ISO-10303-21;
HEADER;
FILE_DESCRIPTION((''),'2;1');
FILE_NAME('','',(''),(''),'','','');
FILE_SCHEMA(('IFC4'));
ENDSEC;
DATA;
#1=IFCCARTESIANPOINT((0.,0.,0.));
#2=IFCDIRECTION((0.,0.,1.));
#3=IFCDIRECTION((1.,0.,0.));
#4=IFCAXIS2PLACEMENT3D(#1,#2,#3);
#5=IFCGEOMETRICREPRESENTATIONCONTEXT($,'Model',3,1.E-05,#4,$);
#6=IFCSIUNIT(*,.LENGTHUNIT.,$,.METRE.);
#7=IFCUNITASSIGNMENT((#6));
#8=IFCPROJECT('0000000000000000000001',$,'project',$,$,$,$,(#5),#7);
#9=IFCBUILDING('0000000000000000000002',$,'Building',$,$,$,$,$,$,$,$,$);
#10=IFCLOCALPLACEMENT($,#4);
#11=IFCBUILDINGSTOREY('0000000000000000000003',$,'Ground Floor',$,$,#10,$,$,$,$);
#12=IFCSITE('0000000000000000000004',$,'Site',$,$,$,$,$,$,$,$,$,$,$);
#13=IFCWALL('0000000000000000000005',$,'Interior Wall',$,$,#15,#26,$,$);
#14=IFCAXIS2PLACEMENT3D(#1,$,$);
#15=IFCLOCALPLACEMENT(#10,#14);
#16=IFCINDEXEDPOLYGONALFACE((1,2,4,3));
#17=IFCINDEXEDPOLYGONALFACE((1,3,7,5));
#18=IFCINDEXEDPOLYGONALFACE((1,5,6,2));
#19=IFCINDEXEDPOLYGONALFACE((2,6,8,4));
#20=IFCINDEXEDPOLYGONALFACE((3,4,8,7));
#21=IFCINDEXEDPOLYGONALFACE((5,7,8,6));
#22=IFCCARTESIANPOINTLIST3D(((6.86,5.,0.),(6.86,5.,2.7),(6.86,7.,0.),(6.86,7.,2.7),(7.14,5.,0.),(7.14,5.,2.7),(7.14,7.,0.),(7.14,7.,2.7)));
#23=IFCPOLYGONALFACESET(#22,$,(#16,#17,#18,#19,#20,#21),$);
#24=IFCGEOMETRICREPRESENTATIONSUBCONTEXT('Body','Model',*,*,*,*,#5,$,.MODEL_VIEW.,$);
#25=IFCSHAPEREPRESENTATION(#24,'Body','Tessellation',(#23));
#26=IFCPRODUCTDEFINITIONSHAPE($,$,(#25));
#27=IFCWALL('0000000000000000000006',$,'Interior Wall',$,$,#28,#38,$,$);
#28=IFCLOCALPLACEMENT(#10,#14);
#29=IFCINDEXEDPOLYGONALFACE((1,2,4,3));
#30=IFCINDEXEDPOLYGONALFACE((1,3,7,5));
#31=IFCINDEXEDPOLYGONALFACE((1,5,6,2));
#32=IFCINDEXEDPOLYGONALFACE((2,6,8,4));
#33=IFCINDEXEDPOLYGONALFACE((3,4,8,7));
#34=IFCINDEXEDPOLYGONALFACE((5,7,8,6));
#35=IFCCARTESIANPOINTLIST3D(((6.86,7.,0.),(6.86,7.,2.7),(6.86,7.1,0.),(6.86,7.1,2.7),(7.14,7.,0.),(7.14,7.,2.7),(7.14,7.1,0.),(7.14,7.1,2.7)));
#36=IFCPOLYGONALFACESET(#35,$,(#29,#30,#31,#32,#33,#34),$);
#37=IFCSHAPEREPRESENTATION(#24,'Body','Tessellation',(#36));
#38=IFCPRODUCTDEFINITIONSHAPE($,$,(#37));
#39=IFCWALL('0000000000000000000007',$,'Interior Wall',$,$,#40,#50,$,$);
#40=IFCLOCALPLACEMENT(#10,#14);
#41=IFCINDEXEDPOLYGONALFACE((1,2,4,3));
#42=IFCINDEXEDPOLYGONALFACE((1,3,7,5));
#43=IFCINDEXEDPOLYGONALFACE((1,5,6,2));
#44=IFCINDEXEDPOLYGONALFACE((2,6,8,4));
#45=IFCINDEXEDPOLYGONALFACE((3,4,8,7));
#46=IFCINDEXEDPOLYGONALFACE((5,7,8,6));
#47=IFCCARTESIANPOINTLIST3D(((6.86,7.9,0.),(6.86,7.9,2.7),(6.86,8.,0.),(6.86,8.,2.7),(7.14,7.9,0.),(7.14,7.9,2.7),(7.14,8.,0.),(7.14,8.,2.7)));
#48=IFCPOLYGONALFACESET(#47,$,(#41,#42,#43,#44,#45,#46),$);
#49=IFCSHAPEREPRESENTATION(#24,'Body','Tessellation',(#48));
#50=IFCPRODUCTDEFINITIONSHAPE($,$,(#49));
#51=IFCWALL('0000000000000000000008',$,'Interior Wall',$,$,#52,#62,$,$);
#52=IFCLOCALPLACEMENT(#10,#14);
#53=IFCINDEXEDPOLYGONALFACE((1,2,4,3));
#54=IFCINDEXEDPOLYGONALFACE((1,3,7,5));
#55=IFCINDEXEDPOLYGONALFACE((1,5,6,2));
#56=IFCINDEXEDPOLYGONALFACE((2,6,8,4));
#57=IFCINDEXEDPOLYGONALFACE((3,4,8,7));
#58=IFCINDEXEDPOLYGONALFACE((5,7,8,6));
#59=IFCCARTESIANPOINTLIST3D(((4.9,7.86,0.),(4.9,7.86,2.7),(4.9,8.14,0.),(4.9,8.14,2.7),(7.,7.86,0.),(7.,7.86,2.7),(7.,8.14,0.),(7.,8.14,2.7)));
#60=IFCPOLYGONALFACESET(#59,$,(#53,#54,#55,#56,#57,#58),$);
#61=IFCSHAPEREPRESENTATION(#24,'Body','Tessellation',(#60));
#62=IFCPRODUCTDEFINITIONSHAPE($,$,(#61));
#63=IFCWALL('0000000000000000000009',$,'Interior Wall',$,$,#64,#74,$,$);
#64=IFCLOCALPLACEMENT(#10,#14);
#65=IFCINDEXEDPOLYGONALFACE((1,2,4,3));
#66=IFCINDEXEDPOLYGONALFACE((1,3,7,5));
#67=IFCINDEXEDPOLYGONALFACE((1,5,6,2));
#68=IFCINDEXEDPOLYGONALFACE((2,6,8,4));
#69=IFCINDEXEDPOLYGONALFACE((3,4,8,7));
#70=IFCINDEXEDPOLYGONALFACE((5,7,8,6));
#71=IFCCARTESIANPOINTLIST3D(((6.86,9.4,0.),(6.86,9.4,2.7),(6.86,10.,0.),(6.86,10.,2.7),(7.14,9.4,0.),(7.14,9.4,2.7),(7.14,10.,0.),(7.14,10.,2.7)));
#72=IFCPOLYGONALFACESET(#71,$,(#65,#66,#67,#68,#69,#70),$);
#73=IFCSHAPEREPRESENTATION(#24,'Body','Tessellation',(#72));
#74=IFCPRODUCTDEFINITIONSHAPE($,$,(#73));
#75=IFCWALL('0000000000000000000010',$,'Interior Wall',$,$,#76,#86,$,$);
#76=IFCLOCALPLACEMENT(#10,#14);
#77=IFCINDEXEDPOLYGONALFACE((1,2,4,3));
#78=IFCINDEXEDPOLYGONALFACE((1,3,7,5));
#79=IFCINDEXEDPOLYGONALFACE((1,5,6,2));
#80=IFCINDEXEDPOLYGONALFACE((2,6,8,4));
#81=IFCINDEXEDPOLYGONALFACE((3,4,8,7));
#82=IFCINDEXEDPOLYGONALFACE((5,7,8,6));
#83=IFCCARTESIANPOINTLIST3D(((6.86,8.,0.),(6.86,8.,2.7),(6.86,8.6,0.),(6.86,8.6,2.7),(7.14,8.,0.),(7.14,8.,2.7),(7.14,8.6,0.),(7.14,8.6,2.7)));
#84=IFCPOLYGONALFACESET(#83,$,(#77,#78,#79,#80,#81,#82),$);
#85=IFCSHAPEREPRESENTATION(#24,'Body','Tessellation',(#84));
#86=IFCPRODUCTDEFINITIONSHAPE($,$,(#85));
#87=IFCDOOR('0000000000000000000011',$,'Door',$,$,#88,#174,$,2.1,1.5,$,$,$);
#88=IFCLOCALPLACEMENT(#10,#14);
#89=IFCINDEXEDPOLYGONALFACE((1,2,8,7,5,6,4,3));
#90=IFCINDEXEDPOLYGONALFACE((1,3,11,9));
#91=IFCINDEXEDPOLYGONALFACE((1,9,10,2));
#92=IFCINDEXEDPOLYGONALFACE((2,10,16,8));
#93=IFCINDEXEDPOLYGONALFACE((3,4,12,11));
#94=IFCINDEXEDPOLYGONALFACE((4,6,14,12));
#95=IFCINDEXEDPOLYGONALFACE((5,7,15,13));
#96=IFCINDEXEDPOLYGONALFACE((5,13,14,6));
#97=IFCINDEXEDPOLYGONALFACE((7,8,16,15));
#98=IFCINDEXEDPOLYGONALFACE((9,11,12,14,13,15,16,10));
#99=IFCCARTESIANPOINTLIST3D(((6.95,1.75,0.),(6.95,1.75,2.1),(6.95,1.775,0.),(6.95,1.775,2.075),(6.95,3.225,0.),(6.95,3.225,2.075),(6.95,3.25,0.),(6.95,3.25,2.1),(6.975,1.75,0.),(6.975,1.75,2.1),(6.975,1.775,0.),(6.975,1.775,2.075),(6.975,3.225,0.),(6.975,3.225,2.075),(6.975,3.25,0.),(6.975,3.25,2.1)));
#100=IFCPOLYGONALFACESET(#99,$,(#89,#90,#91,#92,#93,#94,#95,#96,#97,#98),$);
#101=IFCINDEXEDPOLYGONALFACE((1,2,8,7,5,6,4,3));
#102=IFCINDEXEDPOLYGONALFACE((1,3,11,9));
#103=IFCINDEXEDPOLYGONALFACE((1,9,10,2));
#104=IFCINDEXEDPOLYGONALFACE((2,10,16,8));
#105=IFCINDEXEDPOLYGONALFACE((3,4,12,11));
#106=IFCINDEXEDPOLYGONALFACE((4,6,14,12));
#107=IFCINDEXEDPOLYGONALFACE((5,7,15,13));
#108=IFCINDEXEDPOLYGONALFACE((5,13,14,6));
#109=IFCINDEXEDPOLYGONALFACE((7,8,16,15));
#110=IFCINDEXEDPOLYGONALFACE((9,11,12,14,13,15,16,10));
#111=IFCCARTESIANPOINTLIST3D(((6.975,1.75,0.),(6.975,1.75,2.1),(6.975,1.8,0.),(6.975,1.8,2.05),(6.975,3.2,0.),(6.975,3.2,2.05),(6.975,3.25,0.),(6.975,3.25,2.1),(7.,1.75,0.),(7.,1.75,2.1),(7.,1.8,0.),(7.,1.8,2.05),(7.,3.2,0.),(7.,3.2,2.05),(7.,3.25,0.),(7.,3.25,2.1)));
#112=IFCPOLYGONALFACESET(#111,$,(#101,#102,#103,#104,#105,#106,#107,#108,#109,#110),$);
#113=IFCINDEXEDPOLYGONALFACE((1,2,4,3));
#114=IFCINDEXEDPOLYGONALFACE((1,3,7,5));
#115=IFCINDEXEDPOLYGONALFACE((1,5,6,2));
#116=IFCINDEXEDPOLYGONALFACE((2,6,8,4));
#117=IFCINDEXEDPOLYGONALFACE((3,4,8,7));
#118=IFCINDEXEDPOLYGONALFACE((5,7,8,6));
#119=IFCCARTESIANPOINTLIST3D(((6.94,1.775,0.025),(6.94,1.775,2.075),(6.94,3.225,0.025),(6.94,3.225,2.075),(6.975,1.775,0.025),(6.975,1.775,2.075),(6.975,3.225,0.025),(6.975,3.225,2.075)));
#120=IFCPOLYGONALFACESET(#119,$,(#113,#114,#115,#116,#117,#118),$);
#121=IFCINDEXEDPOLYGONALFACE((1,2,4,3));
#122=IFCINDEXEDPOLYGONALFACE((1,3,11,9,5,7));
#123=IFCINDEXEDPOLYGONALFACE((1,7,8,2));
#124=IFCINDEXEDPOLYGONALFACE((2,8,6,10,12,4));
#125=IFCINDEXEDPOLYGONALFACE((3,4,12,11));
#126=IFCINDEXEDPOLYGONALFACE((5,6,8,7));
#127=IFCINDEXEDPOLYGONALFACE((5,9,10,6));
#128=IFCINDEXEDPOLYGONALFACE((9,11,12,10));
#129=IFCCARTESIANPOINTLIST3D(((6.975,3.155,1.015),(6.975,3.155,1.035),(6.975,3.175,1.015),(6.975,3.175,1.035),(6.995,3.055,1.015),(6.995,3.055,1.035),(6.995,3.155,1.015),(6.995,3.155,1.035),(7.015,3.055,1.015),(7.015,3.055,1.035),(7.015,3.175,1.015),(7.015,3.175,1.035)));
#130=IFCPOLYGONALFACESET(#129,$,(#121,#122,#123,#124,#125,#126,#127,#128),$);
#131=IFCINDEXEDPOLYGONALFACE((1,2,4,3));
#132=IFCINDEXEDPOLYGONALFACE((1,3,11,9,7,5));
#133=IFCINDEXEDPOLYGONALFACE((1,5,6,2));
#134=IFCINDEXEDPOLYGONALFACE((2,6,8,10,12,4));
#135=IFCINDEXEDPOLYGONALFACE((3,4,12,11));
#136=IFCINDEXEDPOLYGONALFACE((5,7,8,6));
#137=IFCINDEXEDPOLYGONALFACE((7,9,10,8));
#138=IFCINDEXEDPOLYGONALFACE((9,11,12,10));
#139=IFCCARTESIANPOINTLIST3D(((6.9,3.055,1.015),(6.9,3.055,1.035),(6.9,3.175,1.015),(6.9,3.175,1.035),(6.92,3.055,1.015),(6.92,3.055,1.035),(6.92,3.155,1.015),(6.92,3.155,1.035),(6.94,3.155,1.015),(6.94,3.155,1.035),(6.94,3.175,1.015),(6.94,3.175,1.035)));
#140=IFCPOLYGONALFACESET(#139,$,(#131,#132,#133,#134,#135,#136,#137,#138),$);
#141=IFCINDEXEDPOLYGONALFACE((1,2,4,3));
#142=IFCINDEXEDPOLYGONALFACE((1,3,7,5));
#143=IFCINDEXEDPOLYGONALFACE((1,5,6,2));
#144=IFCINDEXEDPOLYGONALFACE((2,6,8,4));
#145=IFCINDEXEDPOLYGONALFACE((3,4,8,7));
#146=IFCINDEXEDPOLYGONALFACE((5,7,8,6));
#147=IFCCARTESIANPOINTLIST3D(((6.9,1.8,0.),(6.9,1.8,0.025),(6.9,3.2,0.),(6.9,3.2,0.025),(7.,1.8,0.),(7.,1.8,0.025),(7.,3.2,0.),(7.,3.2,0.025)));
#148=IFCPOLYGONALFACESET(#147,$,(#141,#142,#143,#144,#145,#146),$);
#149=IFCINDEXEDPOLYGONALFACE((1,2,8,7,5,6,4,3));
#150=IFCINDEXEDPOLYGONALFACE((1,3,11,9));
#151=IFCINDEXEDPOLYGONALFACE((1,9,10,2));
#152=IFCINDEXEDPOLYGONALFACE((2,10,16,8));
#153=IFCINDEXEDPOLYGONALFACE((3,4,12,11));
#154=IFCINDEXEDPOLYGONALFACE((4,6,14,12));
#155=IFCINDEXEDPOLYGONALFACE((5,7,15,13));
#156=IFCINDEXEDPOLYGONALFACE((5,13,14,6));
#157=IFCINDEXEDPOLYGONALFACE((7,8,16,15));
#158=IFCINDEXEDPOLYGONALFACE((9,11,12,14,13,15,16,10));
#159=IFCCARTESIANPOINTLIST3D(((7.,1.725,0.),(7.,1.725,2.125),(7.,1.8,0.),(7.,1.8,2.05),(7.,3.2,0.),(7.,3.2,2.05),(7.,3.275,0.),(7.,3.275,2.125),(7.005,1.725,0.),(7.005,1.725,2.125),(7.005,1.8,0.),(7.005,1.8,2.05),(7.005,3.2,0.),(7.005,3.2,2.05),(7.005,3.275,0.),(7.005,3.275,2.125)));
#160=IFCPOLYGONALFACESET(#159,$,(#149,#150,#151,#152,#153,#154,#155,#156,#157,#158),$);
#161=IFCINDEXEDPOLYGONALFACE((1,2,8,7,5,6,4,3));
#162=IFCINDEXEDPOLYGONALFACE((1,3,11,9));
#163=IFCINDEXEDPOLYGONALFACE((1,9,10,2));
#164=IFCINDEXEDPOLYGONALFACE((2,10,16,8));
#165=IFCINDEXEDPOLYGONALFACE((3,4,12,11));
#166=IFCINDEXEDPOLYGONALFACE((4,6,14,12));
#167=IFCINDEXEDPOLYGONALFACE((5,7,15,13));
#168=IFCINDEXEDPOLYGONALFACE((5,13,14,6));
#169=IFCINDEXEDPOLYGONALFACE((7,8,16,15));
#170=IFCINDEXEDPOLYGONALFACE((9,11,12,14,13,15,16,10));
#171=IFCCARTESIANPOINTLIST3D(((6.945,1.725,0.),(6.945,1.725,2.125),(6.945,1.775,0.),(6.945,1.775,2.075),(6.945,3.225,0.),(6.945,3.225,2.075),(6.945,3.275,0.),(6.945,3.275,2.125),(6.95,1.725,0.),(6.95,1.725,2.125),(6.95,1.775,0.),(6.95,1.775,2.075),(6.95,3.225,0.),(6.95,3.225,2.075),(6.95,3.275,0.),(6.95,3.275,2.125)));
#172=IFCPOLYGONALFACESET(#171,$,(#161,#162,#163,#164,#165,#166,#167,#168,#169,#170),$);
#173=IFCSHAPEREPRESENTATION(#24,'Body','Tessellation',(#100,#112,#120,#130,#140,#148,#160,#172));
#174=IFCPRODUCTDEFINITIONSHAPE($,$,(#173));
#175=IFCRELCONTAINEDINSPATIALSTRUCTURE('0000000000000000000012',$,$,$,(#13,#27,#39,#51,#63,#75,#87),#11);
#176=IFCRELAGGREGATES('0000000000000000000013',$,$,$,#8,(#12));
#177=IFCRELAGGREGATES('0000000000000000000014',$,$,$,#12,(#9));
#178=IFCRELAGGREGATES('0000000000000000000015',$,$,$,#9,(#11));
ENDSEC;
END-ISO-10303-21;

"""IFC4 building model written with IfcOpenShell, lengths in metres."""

from ifc_helpers import new_model, si_unit, frame, origin_with_axes, place, context, subcontext, project, spatial, line, indexed_curve, outline, extrude, element, save


model = new_model("IFC4")

# Units and contexts
model_context = context("Model", 3, precision=1e-05, world=origin_with_axes())
body_context = subcontext(model_context, "Body", "Model", "MODEL_VIEW")
ifc_project = project(units=[si_unit("LENGTHUNIT", "METRE")], contexts=[model_context])

# Site, building, storey
site = spatial("IfcSite", under=ifc_project, Name="Site")
building = spatial("IfcBuilding", under=site, Name="Building")
storey_placement = place(None, origin_with_axes())
storey = spatial("IfcBuildingStorey", under=building, at=storey_placement, Name="Ground Floor")

# Walls
wall_1_placement = place(storey_placement, frame((7.0, 7.0, 0.0), z_axis=(0.0, 0.0, 1.0), x_axis=(0.0, -1.0, 0.0)))
element("IfcWall", 1, at=wall_1_placement, inside=storey, Name="Interior Wall", context=body_context, shape_type="SweptSolid", body=[
    extrude(outline(indexed_curve([(0.0, 0.0), (0.0, 0.28), (2.0, 0.28), (2.0, 0.0), (0.0, 0.0)], self_intersect=False)), frame((0.0, -0.14, 0.0), z_axis=(0.0, 0.0, 1.0), x_axis=(1.0, 0.0, 0.0)), (0.0, 0.0, 1.0), 2.7),
])
for number, where, z_axis, x_axis, name in (
    (2, (7.0, 7.0, 0.0), (0.0, 0.0, 1.0), (0.0, 1.0, 0.0), "Interior Wall"),
    (3, (7.0, 7.9, 0.0), (0.0, 0.0, 1.0), (0.0, 1.0, 0.0), "Interior Wall"),
):
    element("IfcWall", number, at=place(storey_placement, frame(where, z_axis=z_axis, x_axis=x_axis)), inside=storey, Name=name, context=body_context, shape_type="SweptSolid", body=[
        extrude(outline(indexed_curve([(0.0, 0.0), (0.0, 0.28), (0.1, 0.28), (0.1, 0.0), (0.0, 0.0)], self_intersect=False)), frame((0.0, -0.14, 0.0), z_axis=(0.0, 0.0, 1.0), x_axis=(1.0, 0.0, 0.0)), (0.0, 0.0, 1.0), 2.7),
    ])
wall_2_placement = place(storey_placement, frame((7.0, 8.0, 0.0), z_axis=(0.0, 0.0, 1.0), x_axis=(-1.0, 0.0, 0.0)))
element("IfcWall", 4, at=wall_2_placement, inside=storey, Name="Interior Wall", context=body_context, shape_type="SweptSolid", body=[
    extrude(outline(indexed_curve([(0.0, 0.0), (0.0, 0.28), (2.1, 0.28), (2.1, 0.0), (0.0, 0.0)], self_intersect=False)), frame((0.0, -0.14, 0.0), z_axis=(0.0, 0.0, 1.0), x_axis=(1.0, 0.0, 0.0)), (0.0, 0.0, 1.0), 2.7),
])
for number, where, z_axis, x_axis, name in (
    (5, (7.0, 10.0, 0.0), (0.0, 0.0, 1.0), (0.0, -1.0, 0.0), "Interior Wall"),
    (6, (7.0, 8.6, 0.0), (0.0, 0.0, 1.0), (0.0, -1.0, 0.0), "Interior Wall"),
):
    element("IfcWall", number, at=place(storey_placement, frame(where, z_axis=z_axis, x_axis=x_axis)), inside=storey, Name=name, context=body_context, shape_type="SweptSolid", body=[
        extrude(outline(indexed_curve([(0.0, 0.0), (0.0, 0.28), (0.6, 0.28), (0.6, 0.0), (0.0, 0.0)], self_intersect=False)), frame((0.0, -0.14, 0.0), z_axis=(0.0, 0.0, 1.0), x_axis=(1.0, 0.0, 0.0)), (0.0, 0.0, 1.0), 2.7),
    ])

# Door
door_1_placement = place(storey_placement, frame((7.0, 1.75, 0.0), z_axis=(0.0, 0.0, 1.0), x_axis=(0.0, 1.0, 0.0)))
element("IfcDoor", 7, at=door_1_placement, inside=storey, Name="Door", OverallHeight=2.1, OverallWidth=1.5, context=body_context, shape_type="SweptSolid", body=[
    extrude(outline(indexed_curve([(0.0, 0.0), (0.0, 2.1), (1.5, 2.1), (1.5, 0.0), (1.475, 0.0), (1.475, 2.075), (0.025, 2.075), (0.025, 0.0)], segments=[line(1, 2, 3, 4, 5, 6, 7, 8, 1)])), frame((0.0, 0.025, 0.0), z_axis=(0.0, -1.0, 0.0), x_axis=(1.0, 0.0, 0.0)), (0.0, 0.0, -1.0), 0.025),
    extrude(outline(indexed_curve([(0.0, 0.0), (0.0, 2.1), (1.5, 2.1), (1.5, 0.0), (1.45, 0.0), (1.45, 2.05), (0.05, 2.05), (0.05, 0.0)], segments=[line(1, 2, 3, 4, 5, 6, 7, 8, 1)])), frame((0.0, 0.0, 0.0), z_axis=(0.0, -1.0, 0.0), x_axis=(1.0, 0.0, 0.0)), (0.0, 0.0, -1.0), 0.025),
    extrude(outline(indexed_curve([(0.0, 0.0), (1.45, 0.0), (1.45, 0.035), (0.0, 0.035)], segments=[line(1, 2, 3, 4, 1)])), frame((0.025, 0.025, 0.025), z_axis=(0.0, 0.0, 1.0), x_axis=(1.0, 0.0, 0.0)), (0.0, 0.0, 1.0), 2.05),
    extrude(outline(indexed_curve([(0.0, 0.0), (0.0, -0.04), (-0.12, -0.04), (-0.12, -0.02), (-0.02, -0.02), (-0.02, 0.0)], segments=[line(1, 2, 3, 4, 5, 6, 1)])), frame((1.425, 0.025, 1.015), z_axis=(0.0, 0.0, 1.0), x_axis=(1.0, 0.0, 0.0)), (0.0, 0.0, 1.0), 0.02),
    extrude(outline(indexed_curve([(0.0, 0.0), (0.0, 0.04), (-0.12, 0.04), (-0.12, 0.02), (-0.02, 0.02), (-0.02, 0.0)], segments=[line(1, 2, 3, 4, 5, 6, 1)])), frame((1.425, 0.06, 1.015), z_axis=(0.0, 0.0, 1.0), x_axis=(1.0, 0.0, 0.0)), (0.0, 0.0, 1.0), 0.02),
    extrude(outline(indexed_curve([(0.0, 0.0), (1.4, 0.0), (1.4, 0.1), (0.0, 0.1)], segments=[line(1, 2, 3, 4, 1)])), frame((0.05, 0.0, 0.0), z_axis=(0.0, 0.0, 1.0), x_axis=(1.0, 0.0, 0.0)), (0.0, 0.0, 1.0), 0.025),
    extrude(outline(indexed_curve([(0.0, 0.0), (0.0, 2.125), (1.55, 2.125), (1.55, 0.0), (1.475, 0.0), (1.475, 2.05), (0.075, 2.05), (0.075, 0.0)], segments=[line(1, 2, 3, 4, 5, 6, 7, 8, 1)])), frame((-0.025, -0.005, 0.0), z_axis=(0.0, -1.0, 0.0), x_axis=(1.0, 0.0, 0.0)), (0.0, 0.0, -1.0), 0.005),
    extrude(outline(indexed_curve([(0.0, 0.0), (0.0, 2.125), (1.55, 2.125), (1.55, 0.0), (1.5, 0.0), (1.5, 2.075), (0.05, 2.075), (0.05, 0.0)], segments=[line(1, 2, 3, 4, 5, 6, 7, 8, 1)])), frame((-0.025, 0.05, 0.0), z_axis=(0.0, -1.0, 0.0), x_axis=(1.0, 0.0, 0.0)), (0.0, 0.0, -1.0), 0.005),
])

save(model, "model.ifc")
